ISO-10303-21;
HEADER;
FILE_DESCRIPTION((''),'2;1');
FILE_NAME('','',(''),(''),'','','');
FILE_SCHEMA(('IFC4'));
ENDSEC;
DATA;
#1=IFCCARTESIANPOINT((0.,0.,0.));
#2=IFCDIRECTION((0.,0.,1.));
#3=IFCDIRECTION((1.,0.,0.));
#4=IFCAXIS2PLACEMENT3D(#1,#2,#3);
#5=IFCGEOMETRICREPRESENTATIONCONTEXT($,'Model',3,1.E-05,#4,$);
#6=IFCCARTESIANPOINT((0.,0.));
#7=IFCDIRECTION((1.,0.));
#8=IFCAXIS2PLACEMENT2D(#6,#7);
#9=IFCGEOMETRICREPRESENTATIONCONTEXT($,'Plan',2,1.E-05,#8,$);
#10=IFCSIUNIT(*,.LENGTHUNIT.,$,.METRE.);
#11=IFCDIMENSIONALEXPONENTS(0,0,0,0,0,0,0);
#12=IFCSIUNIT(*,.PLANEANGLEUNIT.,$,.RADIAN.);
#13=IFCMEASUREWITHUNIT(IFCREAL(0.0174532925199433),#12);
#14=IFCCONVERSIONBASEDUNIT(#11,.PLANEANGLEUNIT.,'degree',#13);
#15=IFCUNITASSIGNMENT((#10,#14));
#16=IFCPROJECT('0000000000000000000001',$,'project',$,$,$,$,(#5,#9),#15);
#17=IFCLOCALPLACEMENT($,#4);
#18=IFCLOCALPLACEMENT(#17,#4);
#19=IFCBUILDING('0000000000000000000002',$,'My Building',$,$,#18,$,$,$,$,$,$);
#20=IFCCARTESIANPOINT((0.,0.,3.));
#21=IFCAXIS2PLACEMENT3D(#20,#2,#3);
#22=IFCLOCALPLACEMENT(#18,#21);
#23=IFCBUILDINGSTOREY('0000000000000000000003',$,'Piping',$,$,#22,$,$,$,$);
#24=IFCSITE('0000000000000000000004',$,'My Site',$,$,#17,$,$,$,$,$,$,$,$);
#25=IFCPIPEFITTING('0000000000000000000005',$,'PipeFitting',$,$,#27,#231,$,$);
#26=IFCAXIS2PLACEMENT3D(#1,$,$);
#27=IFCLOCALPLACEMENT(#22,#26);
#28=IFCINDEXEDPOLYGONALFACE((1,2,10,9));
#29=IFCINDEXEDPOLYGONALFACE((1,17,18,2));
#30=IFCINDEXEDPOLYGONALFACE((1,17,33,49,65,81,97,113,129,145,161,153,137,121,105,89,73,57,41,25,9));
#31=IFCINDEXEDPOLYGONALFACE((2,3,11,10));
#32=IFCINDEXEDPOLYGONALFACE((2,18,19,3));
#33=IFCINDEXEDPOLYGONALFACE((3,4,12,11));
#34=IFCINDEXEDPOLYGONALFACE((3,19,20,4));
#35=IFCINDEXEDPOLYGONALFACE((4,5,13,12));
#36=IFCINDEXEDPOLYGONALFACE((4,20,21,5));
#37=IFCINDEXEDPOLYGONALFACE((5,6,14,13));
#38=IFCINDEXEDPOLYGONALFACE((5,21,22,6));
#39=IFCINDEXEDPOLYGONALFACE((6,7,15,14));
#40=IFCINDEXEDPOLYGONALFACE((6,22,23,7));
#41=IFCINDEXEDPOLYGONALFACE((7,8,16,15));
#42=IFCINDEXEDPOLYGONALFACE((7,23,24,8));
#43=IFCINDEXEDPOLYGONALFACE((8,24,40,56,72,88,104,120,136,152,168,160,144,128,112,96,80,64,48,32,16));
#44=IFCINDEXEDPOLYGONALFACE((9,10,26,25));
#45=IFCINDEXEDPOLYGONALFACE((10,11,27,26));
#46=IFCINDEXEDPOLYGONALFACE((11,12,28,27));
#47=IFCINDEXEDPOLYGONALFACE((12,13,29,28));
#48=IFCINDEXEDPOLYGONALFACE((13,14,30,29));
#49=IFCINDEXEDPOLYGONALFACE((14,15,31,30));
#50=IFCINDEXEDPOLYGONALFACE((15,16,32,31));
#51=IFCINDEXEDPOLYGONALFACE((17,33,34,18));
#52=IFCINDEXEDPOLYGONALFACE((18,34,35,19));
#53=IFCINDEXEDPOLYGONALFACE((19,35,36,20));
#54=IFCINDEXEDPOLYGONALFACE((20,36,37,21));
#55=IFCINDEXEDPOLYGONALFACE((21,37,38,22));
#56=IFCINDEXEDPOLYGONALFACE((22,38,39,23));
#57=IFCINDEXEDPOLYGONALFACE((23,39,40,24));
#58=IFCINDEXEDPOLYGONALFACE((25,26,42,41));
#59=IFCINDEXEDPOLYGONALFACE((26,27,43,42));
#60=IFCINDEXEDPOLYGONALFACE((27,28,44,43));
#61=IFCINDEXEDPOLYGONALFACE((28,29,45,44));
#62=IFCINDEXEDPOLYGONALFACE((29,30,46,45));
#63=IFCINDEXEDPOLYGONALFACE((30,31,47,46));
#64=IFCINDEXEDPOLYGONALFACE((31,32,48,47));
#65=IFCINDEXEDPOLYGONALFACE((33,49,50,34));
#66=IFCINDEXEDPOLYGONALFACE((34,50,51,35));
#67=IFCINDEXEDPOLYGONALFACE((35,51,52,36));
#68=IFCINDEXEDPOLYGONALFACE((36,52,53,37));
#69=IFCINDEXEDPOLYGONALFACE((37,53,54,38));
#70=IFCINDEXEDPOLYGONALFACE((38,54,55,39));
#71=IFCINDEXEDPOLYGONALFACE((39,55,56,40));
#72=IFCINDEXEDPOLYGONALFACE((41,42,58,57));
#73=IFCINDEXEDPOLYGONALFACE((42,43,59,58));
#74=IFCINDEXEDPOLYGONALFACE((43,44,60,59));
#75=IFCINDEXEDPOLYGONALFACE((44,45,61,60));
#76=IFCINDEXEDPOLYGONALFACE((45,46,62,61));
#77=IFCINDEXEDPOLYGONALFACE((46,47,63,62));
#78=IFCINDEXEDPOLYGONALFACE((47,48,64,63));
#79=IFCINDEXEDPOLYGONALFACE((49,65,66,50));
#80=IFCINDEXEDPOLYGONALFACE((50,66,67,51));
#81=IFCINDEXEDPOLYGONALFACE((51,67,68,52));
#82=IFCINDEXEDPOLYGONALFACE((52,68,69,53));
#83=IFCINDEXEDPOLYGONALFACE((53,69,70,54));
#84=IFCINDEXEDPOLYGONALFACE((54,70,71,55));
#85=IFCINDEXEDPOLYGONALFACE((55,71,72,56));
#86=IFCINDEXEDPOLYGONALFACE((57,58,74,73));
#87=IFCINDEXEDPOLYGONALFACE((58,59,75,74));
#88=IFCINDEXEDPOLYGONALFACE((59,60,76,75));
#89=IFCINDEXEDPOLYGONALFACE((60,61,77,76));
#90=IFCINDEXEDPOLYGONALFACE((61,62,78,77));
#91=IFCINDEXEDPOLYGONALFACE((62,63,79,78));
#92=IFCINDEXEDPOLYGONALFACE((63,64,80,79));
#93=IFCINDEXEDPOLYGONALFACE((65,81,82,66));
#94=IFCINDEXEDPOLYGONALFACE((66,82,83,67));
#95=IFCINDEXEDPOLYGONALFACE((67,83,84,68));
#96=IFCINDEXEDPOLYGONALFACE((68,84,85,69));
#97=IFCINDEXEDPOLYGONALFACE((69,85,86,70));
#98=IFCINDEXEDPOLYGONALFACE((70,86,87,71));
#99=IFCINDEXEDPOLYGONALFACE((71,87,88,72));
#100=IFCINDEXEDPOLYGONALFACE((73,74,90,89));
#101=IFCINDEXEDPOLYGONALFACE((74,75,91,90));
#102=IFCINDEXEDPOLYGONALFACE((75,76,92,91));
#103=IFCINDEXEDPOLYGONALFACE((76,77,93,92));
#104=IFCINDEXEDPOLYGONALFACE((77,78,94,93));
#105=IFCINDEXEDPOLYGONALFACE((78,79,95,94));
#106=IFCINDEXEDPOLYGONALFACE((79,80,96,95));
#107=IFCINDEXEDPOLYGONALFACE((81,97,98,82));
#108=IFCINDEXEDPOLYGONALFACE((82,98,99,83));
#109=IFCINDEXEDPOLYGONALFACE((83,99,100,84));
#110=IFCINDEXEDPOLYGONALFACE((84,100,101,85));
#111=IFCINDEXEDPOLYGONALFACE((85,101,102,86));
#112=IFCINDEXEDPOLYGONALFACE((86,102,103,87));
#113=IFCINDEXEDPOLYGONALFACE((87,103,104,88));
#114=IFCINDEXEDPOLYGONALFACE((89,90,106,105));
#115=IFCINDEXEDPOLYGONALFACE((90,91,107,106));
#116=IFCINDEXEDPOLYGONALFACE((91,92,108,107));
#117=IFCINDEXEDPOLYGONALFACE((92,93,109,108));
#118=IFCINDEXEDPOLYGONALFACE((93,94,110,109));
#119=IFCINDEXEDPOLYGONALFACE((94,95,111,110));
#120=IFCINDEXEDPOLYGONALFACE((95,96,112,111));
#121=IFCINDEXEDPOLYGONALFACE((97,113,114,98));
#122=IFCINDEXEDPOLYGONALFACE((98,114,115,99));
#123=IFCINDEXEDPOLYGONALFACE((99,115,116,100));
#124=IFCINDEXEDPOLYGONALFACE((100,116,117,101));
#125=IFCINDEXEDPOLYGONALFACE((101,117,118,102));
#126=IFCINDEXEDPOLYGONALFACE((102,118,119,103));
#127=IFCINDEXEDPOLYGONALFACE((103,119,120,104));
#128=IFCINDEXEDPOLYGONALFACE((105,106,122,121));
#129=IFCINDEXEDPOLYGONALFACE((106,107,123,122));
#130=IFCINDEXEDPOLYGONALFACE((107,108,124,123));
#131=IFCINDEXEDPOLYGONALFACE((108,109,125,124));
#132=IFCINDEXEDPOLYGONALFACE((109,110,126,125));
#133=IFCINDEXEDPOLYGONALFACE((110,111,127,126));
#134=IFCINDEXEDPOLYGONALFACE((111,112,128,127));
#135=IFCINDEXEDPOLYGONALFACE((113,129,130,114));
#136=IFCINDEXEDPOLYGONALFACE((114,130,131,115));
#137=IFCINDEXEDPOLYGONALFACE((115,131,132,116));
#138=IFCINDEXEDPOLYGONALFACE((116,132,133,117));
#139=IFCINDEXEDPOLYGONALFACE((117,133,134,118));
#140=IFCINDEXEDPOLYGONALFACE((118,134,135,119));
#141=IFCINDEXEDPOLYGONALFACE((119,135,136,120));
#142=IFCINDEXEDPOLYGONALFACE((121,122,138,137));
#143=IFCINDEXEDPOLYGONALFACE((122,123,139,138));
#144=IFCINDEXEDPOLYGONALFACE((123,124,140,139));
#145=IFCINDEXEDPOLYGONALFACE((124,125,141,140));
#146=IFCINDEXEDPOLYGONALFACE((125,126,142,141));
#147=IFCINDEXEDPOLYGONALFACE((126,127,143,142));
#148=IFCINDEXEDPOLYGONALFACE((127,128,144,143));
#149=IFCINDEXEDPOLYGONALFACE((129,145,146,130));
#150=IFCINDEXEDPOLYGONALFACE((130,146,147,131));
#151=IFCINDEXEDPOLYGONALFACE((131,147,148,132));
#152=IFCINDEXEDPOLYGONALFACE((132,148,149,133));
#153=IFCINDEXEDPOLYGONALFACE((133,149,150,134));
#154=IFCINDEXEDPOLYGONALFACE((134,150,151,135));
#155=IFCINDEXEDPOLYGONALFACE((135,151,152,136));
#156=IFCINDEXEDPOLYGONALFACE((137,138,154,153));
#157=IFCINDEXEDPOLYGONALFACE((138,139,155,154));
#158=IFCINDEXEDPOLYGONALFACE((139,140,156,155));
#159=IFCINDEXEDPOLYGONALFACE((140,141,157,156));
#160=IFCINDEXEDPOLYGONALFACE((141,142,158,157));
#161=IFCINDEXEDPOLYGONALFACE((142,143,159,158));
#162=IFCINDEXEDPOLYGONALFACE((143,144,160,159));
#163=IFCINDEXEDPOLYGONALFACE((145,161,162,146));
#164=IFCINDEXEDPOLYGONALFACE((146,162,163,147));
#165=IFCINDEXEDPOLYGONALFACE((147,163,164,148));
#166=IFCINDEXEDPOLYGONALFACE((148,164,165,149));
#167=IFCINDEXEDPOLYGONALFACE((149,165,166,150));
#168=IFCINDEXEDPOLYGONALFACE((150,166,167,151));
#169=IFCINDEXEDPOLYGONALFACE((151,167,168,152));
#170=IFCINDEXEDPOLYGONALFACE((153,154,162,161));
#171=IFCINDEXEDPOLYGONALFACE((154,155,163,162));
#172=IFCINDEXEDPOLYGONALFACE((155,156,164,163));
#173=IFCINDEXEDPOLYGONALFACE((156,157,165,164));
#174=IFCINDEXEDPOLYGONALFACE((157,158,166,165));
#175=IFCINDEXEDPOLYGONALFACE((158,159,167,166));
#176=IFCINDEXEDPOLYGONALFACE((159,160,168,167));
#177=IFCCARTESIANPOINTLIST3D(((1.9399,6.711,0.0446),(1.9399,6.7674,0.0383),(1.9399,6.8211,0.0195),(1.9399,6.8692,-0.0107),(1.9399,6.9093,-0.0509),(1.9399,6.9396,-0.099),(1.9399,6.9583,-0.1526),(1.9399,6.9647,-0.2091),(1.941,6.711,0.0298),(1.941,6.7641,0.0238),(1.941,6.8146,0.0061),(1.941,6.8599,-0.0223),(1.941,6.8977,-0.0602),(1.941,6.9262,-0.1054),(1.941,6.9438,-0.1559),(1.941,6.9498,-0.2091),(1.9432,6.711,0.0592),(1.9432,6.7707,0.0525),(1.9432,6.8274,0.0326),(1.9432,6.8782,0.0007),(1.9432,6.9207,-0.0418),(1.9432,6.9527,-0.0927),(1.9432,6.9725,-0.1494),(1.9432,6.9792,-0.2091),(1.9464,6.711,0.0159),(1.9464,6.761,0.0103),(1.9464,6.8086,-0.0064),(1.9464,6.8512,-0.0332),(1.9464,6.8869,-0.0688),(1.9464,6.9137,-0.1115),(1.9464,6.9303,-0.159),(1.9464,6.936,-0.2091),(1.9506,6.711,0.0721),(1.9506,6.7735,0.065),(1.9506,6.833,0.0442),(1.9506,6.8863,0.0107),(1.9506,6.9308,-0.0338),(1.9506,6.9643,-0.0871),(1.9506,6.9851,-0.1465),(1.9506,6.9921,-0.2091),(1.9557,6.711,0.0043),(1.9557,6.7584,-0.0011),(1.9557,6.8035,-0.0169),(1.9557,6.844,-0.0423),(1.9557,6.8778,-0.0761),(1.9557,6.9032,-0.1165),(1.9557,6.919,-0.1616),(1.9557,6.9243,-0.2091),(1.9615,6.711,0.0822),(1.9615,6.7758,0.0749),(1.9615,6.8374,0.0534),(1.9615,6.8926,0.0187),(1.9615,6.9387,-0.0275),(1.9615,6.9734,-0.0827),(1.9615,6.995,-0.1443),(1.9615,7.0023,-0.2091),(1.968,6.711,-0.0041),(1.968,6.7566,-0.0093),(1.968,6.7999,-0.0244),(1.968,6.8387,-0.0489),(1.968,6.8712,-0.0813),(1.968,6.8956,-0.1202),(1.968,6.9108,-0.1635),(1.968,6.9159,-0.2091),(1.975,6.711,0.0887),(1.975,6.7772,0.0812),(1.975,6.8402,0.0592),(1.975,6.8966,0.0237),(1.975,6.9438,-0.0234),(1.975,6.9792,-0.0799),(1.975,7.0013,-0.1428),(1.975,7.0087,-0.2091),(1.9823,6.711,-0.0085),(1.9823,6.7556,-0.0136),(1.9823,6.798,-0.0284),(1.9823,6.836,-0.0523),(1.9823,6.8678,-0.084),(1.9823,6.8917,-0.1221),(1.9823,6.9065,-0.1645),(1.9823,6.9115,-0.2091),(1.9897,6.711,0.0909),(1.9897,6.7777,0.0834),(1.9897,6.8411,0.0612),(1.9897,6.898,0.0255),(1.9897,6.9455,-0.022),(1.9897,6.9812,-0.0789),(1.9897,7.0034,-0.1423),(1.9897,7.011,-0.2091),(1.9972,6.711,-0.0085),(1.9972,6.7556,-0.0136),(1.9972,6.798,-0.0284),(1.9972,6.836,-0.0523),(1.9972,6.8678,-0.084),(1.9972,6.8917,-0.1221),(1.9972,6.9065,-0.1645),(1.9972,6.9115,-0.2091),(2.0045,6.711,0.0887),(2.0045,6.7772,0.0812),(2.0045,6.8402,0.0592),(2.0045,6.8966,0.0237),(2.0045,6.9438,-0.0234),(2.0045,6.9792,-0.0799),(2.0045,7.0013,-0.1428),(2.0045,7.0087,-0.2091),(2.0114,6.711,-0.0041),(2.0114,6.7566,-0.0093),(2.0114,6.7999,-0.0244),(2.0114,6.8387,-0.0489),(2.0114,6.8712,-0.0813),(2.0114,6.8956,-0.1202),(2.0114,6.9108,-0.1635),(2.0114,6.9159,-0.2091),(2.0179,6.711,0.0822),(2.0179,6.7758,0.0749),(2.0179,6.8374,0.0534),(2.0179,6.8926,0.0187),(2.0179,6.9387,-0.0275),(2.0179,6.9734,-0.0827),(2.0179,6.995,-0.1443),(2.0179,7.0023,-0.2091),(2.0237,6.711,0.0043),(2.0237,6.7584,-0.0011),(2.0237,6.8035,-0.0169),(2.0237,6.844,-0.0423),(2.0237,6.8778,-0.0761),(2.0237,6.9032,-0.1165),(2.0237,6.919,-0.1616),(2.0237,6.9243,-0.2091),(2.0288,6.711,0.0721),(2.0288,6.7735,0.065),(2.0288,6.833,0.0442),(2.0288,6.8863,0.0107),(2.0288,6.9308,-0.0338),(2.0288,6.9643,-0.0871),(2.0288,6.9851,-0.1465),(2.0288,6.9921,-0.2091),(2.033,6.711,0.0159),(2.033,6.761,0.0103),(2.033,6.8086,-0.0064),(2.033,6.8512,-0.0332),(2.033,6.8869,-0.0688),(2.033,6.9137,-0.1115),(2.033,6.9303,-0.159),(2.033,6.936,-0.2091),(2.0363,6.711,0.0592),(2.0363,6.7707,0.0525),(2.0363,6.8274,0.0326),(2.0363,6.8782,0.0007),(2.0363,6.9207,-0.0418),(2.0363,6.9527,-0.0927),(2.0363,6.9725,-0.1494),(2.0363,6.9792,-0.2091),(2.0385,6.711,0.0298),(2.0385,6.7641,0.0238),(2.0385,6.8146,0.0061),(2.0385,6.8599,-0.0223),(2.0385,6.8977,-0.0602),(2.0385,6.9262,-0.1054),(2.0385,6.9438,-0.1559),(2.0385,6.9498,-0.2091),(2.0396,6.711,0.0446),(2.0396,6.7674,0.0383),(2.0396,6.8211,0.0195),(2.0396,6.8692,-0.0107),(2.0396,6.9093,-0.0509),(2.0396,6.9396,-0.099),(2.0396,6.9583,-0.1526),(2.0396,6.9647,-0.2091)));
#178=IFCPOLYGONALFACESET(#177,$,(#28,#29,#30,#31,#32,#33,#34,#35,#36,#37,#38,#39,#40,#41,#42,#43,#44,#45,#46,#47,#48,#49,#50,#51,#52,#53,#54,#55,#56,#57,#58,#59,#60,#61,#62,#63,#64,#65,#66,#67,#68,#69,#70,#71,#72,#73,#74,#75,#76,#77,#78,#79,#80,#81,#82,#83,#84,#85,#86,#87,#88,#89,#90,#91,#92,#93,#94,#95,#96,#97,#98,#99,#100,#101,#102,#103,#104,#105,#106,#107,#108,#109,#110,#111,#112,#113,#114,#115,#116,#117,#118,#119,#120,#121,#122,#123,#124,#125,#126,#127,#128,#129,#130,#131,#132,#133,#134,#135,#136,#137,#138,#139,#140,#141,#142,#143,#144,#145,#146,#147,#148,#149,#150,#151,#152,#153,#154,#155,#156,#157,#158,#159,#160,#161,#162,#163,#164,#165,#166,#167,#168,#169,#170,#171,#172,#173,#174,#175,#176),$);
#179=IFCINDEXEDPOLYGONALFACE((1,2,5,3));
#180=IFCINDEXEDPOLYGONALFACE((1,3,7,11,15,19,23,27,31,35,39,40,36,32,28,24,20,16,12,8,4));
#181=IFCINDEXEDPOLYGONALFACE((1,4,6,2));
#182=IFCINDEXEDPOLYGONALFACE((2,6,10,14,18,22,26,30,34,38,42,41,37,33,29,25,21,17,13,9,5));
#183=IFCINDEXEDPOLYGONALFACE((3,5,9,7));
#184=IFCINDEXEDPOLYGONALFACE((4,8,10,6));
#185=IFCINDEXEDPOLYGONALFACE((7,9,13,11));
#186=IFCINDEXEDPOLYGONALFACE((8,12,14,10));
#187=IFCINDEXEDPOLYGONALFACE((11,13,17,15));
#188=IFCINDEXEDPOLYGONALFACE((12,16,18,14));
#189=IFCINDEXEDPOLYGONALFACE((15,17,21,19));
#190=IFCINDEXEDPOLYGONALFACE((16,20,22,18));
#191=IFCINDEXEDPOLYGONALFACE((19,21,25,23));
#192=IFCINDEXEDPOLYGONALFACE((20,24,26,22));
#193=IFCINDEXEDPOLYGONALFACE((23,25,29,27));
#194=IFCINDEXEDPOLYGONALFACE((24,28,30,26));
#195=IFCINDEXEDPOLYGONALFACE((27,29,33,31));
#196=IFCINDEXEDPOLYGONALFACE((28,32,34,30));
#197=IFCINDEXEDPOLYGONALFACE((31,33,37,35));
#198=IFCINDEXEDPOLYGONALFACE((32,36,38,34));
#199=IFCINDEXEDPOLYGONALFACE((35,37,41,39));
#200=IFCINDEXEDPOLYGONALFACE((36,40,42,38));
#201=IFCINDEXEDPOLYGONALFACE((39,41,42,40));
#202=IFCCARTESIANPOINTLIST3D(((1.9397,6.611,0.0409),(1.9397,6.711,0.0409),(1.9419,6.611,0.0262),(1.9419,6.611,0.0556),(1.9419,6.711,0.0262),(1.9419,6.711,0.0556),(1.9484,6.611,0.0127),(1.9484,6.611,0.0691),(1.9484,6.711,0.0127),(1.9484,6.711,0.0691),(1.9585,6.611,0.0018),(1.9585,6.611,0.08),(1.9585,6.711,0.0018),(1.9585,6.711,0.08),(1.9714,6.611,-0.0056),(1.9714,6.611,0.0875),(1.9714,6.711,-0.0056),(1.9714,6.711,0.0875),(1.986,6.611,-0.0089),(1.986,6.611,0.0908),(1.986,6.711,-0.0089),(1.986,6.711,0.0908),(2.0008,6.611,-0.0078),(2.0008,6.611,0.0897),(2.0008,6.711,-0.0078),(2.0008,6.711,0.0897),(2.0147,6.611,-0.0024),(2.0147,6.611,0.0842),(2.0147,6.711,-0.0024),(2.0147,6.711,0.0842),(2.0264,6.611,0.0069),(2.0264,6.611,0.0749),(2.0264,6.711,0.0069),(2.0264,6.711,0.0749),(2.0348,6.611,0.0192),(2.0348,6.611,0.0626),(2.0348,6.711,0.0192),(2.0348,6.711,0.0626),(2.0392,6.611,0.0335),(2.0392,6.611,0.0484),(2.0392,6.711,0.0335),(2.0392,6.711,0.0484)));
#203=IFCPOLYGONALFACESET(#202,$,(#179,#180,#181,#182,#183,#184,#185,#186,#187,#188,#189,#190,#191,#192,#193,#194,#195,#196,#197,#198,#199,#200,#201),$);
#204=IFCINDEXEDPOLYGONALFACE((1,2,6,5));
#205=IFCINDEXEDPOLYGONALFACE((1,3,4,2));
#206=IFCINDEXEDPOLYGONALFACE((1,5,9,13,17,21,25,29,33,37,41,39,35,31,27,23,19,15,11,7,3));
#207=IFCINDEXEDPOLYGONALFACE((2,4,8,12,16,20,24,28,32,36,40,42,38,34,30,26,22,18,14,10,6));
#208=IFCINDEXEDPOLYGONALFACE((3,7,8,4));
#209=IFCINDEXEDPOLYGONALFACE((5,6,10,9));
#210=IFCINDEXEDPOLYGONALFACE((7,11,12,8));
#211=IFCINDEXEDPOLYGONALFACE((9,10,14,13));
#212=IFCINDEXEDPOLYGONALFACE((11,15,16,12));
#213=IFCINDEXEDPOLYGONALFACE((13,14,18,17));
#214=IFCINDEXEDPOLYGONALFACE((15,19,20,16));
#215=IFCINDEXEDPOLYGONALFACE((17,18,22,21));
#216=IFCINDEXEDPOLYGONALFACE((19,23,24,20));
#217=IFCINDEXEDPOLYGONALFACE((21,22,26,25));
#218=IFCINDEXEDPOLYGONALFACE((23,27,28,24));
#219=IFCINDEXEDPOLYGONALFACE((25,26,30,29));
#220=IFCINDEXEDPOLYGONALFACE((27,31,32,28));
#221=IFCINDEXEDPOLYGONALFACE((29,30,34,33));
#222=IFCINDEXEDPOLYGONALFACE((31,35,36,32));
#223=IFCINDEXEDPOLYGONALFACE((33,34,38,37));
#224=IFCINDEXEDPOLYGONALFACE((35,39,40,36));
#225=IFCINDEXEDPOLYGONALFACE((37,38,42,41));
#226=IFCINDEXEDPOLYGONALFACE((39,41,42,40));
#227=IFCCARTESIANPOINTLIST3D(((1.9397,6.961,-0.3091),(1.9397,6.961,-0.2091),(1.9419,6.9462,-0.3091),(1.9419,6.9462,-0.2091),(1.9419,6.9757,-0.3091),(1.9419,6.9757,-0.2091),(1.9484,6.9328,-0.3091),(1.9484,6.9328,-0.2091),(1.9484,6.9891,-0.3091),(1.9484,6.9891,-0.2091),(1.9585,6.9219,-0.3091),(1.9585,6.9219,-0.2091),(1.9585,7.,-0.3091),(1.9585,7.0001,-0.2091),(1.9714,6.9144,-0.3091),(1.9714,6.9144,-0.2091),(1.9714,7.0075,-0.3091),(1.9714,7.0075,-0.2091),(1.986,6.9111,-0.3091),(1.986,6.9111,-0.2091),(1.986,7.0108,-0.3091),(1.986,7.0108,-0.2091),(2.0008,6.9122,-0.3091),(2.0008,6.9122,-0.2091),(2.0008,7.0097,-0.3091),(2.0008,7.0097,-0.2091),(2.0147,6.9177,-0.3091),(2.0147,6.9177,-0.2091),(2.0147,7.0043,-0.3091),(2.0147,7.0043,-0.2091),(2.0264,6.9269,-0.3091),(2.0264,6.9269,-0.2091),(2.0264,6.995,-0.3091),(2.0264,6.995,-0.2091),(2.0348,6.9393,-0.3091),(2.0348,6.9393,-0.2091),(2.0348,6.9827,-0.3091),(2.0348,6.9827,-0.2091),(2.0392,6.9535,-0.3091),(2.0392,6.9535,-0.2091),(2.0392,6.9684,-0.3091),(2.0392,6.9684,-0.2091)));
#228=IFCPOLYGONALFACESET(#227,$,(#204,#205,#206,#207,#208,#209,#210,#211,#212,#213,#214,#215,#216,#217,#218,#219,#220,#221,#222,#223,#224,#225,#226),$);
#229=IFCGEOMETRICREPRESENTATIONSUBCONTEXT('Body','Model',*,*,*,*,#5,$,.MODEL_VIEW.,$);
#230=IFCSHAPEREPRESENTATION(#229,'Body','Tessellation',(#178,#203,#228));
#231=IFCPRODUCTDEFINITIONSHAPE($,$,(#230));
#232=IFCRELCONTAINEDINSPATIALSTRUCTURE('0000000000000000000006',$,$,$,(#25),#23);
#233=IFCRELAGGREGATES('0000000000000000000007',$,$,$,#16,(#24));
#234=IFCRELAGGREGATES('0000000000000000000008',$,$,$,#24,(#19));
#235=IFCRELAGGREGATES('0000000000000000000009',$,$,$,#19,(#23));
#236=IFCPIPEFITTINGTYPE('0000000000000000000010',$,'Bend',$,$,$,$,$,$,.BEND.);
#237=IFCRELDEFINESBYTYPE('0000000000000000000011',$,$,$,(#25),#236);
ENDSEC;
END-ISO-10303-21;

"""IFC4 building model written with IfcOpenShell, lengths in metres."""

from ifc_helpers import new_model, entity, si_unit, converted_unit, frame, origin_with_axes, origin_2d_with_axis, place, context, subcontext, project, spatial, circle, extrude, source, transform, mapped, type_object, type_shapes, element, save


model = new_model("IFC4")

# Units and contexts
model_context = context("Model", 3, precision=1e-05, world=origin_with_axes())
plan_context = context("Plan", 2, precision=1e-05, world=origin_2d_with_axis())
body_context = subcontext(model_context, "Body", "Model", "MODEL_VIEW")
ifc_project = project(units=[si_unit("LENGTHUNIT", "METRE"), converted_unit("PLANEANGLEUNIT", "degree", entity("IfcReal", 0.0174532925199433), si_unit("PLANEANGLEUNIT", "RADIAN"), dimensions=[0, 0, 0, 0, 0, 0, 0])], contexts=[model_context, plan_context])

# Site, building, storey
site_placement = place(None, origin_with_axes())
site = spatial("IfcSite", under=ifc_project, at=site_placement, Name="My Site")
building_placement = place(site_placement, origin_with_axes())
building = spatial("IfcBuilding", under=site, at=building_placement, Name="My Building")
storey_placement = place(building_placement, frame((0.0, 0.0, 3.0), z_axis=(0.0, 0.0, 1.0), x_axis=(1.0, 0.0, 0.0)))
storey = spatial("IfcBuildingStorey", under=building, at=storey_placement, Name="Piping")

# Pipe fitting
pipe_fitting_type_1 = type_object("IfcPipeFittingType", Name="Bend", PredefinedType="BEND")
shared_shape = source(origin_with_axes(), body_context, "Body", "SolidModel", [
    entity("IfcSweptDiskSolid", entity("IfcIndexedPolyCurve", entity("IfcCartesianPointList3D", [[0.0, 0.0, 0.1], [0.0, -0.0732, 0.2768], [0.0, -0.25, 0.35]]), [entity("IfcArcIndex", [1, 2, 3])]), 0.05),
    extrude(circle(Radius=0.05), origin_with_axes(), (0.0, 0.0, 1.0), 0.1),
    extrude(circle(Radius=0.05), frame((0.0, -0.25, 0.35), z_axis=(0.0, -1.0, -0.000003), x_axis=(1.0, 0.0, 0.0)), (0.0, 0.0, 1.0), 0.1),
])
type_shapes(pipe_fitting_type_1, [shared_shape])
for number, where, z_axis, x_axis, name in (
    (1, (1.9897, 6.611, 0.0409), (-0.000001, 1.0, 0.0), (-1.0, -0.000001, 0.0), "PipeFitting"),
):
    element("IfcPipeFitting", number, at=place(storey_placement, frame(where, z_axis=z_axis, x_axis=x_axis)), inside=storey, type_object=pipe_fitting_type_1, Name=name, context=body_context, shape_type="MappedRepresentation", body=[
        mapped(shared_shape, transform((0.0, 0.0, 0.0), x_axis=(1.0, 0.0, 0.0), y_axis=(0.0, 1.0, 0.0), z_axis=(0.0, 0.0, 1.0), scale=1.0)),
    ])

save(model, "model.ifc")
